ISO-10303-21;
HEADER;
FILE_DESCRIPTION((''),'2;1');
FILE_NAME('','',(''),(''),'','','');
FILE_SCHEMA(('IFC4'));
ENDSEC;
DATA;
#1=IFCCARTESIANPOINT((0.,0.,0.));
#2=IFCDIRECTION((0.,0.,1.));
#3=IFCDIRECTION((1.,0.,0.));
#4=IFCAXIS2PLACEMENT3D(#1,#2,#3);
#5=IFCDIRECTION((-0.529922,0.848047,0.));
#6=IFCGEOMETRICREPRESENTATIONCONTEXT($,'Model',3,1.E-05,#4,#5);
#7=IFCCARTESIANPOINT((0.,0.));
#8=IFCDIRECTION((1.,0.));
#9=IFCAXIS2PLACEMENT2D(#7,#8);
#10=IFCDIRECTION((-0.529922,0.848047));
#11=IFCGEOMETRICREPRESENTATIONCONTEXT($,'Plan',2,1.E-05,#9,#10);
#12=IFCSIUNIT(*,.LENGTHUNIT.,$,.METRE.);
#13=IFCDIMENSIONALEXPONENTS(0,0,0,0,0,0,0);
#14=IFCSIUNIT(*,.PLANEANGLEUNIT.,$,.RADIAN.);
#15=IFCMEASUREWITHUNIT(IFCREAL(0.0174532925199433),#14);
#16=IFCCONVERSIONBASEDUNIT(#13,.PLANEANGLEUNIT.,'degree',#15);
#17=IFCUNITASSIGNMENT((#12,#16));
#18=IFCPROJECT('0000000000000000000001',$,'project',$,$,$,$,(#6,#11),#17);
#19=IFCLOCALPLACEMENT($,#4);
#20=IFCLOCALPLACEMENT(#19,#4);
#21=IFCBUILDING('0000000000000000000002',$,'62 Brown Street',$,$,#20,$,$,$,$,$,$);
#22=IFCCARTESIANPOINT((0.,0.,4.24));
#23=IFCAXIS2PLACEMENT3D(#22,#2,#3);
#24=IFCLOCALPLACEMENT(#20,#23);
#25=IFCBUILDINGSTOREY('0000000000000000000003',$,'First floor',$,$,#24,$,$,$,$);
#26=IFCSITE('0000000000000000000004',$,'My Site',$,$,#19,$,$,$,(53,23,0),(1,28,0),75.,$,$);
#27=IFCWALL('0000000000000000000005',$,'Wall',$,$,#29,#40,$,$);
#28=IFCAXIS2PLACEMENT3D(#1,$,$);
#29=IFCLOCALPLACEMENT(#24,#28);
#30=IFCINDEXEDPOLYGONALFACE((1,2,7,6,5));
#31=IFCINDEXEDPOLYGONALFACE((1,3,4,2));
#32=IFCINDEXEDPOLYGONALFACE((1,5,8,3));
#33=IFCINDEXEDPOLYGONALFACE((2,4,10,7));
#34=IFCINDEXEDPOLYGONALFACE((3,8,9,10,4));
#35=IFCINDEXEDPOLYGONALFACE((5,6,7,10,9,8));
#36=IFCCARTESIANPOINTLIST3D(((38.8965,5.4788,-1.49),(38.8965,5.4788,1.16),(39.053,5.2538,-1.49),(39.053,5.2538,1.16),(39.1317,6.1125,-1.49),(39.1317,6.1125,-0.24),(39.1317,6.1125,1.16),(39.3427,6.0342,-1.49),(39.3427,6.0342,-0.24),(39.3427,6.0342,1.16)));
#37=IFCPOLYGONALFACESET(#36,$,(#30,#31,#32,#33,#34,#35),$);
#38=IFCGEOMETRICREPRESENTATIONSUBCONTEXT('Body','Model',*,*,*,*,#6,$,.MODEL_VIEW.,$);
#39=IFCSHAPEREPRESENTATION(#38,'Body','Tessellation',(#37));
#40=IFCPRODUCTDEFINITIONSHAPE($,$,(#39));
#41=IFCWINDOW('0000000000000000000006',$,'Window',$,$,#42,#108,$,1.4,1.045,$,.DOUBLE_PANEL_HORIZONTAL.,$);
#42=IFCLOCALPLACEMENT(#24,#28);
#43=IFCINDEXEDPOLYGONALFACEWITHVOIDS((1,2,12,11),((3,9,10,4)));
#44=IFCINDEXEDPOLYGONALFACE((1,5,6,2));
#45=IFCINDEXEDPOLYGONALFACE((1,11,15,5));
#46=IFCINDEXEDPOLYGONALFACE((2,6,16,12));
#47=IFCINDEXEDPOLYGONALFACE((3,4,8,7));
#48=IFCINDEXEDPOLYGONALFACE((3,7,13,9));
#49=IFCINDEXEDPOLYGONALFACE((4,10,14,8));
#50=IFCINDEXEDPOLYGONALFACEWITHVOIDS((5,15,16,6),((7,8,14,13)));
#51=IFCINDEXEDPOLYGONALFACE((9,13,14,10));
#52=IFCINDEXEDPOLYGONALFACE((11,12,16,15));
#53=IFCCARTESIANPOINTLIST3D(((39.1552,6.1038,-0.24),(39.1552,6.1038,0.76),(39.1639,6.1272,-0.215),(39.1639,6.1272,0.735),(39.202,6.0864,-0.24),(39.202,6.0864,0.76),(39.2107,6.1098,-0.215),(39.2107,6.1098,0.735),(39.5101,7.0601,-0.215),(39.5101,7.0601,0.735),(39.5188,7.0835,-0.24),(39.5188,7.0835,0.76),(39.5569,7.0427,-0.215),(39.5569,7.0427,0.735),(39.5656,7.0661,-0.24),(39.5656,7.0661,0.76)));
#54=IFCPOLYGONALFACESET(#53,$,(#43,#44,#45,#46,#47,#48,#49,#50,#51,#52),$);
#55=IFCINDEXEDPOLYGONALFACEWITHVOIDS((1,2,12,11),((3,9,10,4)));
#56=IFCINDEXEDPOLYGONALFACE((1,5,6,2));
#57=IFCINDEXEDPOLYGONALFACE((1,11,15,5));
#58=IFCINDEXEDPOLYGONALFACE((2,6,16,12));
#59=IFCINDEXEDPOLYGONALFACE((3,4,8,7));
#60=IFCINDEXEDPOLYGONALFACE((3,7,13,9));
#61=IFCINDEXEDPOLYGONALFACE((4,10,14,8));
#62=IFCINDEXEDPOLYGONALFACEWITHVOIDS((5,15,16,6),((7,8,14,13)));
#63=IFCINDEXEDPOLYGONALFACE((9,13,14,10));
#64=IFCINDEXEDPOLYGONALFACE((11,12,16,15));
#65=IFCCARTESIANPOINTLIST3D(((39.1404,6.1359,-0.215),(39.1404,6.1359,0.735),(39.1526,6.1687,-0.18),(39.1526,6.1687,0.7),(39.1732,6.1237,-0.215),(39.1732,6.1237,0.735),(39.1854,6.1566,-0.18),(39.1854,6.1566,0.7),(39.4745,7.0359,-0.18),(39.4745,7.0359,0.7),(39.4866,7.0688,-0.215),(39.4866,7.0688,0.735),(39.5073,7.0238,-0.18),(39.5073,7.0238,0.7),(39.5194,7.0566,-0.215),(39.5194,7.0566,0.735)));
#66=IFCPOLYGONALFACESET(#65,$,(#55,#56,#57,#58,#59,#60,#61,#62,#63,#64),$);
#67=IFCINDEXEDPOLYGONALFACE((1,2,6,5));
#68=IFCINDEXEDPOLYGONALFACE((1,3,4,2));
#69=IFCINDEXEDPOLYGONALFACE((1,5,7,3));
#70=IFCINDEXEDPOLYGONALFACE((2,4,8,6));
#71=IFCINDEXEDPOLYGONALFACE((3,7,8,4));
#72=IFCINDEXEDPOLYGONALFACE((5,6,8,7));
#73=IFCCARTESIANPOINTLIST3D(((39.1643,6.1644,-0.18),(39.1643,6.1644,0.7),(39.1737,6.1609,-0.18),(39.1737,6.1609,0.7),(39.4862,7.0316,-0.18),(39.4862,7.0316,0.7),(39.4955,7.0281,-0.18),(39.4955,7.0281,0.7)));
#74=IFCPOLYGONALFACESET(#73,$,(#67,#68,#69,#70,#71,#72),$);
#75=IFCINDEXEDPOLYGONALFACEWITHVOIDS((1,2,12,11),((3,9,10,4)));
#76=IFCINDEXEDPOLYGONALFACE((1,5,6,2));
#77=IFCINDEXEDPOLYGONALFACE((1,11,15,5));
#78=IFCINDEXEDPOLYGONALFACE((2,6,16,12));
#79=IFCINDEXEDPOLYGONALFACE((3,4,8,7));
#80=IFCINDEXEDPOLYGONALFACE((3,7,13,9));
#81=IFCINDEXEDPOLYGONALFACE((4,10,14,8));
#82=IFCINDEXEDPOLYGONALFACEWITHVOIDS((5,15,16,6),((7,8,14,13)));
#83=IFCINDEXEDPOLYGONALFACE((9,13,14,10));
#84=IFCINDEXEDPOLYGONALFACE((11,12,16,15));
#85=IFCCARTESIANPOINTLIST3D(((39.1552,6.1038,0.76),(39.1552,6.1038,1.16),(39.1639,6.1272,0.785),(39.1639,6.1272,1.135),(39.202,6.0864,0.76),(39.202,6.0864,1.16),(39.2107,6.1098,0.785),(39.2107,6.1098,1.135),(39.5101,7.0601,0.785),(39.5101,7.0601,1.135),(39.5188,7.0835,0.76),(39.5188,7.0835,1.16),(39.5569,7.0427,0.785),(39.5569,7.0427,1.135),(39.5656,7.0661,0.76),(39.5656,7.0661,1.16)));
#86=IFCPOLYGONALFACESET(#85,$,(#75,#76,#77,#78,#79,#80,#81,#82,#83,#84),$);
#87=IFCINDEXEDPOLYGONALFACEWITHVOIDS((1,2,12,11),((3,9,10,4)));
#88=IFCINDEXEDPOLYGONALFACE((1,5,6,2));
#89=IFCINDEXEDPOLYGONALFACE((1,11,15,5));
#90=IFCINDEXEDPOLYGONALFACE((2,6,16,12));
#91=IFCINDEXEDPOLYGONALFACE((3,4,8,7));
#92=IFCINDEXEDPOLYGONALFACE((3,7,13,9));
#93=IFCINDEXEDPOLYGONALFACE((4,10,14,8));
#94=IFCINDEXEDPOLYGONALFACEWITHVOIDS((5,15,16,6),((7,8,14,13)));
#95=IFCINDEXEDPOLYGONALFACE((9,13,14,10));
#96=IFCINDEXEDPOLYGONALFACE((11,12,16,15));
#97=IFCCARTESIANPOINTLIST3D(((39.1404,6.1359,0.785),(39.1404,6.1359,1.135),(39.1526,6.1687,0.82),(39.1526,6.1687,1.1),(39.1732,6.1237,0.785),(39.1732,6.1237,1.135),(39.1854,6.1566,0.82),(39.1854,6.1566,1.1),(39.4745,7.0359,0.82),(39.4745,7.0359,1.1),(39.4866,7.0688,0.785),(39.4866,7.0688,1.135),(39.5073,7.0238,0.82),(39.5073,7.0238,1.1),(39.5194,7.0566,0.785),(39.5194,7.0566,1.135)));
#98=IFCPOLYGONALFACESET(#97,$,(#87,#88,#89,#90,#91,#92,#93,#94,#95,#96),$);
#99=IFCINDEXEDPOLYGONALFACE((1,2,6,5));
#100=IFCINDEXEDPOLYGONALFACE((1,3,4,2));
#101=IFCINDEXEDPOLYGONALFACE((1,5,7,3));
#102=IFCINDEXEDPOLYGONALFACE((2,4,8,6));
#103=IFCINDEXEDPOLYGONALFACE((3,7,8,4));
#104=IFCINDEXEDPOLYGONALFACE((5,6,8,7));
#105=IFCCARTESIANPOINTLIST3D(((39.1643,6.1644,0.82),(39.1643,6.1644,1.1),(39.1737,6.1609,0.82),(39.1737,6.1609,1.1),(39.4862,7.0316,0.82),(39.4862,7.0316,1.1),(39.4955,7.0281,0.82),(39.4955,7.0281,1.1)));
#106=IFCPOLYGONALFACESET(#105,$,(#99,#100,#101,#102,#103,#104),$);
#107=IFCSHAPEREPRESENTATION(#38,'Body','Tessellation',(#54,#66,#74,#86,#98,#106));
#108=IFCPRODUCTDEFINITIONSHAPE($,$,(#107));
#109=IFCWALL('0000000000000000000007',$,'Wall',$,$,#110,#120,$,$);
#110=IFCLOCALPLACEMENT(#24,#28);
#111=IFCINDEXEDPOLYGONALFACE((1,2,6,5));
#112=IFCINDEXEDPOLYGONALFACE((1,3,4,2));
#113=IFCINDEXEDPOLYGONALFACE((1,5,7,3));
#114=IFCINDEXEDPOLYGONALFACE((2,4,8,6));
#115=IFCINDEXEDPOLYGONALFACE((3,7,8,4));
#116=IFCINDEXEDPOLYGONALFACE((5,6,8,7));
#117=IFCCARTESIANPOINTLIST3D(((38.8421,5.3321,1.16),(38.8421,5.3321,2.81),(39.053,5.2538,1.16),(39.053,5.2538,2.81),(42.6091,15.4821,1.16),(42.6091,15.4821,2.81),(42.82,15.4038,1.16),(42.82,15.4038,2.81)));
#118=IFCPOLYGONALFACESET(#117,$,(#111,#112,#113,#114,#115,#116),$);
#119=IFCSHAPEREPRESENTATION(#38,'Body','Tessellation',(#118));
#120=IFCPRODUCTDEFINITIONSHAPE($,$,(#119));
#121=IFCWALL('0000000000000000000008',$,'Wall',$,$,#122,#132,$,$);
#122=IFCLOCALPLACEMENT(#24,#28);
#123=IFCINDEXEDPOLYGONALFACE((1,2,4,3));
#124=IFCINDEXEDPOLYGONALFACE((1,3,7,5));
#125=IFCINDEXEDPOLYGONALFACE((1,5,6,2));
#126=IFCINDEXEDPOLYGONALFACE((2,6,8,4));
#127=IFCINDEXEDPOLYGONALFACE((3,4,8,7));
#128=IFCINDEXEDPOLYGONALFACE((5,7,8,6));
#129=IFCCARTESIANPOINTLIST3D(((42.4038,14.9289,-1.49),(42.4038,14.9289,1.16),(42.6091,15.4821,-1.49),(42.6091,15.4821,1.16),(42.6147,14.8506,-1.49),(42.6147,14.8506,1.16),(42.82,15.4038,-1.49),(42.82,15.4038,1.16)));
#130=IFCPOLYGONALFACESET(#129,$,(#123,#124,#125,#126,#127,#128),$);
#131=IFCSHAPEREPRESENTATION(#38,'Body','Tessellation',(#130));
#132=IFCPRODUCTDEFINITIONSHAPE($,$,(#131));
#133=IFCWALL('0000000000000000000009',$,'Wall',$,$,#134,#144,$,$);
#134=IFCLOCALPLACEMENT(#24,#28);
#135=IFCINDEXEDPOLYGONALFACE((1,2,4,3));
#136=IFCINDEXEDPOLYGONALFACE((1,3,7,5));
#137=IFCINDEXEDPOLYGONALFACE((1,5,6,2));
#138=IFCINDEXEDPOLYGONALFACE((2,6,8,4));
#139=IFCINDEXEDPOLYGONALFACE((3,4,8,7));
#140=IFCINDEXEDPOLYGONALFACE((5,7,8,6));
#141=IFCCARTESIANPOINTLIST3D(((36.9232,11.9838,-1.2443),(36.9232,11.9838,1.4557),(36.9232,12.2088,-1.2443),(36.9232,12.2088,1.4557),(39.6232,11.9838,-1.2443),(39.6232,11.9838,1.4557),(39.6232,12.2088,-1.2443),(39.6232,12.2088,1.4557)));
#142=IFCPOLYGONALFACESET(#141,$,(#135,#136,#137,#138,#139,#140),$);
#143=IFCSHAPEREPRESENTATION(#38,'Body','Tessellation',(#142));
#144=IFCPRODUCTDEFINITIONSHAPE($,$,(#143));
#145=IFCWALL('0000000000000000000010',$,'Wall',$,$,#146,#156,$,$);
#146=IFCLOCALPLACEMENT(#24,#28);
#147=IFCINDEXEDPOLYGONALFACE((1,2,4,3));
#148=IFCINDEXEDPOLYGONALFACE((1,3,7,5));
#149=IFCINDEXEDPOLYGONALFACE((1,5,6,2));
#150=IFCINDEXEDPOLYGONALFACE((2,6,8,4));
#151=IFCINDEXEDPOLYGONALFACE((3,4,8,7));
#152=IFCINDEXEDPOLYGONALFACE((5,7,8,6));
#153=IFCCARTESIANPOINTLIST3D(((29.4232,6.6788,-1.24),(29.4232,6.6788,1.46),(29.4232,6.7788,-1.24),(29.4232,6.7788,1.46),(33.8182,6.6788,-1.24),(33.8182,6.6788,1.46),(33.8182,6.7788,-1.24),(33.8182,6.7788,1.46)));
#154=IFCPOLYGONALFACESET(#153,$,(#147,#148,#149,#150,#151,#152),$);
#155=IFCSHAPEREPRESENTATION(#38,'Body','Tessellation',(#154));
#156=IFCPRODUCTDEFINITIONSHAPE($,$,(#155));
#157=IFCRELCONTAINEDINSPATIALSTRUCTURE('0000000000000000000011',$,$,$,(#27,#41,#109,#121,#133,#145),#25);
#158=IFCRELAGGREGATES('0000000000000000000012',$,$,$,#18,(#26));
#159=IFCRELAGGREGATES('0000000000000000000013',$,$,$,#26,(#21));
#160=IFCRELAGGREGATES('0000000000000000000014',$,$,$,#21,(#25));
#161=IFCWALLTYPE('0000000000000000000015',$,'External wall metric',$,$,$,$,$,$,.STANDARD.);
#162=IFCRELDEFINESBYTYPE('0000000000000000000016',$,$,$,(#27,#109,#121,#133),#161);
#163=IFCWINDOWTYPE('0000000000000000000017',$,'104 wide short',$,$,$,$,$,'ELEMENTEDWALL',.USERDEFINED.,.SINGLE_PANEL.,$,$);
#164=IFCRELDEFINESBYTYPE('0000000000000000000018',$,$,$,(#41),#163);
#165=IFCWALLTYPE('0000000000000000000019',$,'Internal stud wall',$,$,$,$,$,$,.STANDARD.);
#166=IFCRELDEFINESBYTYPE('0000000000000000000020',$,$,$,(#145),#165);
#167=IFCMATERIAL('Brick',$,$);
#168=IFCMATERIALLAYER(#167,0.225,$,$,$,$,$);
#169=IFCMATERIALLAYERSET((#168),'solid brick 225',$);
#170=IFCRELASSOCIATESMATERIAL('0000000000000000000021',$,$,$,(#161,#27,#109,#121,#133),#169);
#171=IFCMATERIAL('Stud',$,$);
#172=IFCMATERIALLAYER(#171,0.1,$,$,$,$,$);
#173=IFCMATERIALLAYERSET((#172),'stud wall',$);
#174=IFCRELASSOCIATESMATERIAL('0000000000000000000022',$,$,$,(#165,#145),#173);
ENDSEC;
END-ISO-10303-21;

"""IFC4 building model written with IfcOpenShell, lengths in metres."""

from ifc_helpers import new_model, entity, si_unit, converted_unit, direction, frame, origin_with_axes, origin_2d_with_axis, place, context, subcontext, project, spatial, line, indexed_curve, outline, extrude, clip, halfspace, shape, source, transform, mapped, material, layer, layer_set, layer_usage, type_object, type_shapes, element, fill, save


model = new_model("IFC4")

# Units and contexts
model_context = context("Model", 3, precision=1e-05, world=origin_with_axes(), true_north=direction((-0.529922, 0.848047, 0.0)))
plan_context = context("Plan", 2, precision=1e-05, world=origin_2d_with_axis(), true_north=direction((-0.529922, 0.848047)))
body_context_1 = subcontext(model_context, "Body", "Model", "MODEL_VIEW")
body_context_2 = subcontext(plan_context, "Body", "Plan", "PLAN_VIEW")
ifc_project = project(units=[si_unit("LENGTHUNIT", "METRE"), converted_unit("PLANEANGLEUNIT", "degree", entity("IfcReal", 0.0174532925199433), si_unit("PLANEANGLEUNIT", "RADIAN"), dimensions=[0, 0, 0, 0, 0, 0, 0])], contexts=[model_context, plan_context])

# Site, building, storey
site_placement = place(None, origin_with_axes())
site = spatial("IfcSite", under=ifc_project, at=site_placement, Name="My Site", RefLatitude=(53, 23, 0), RefLongitude=(1, 28, 0), RefElevation=75.0)
building_placement = place(site_placement, origin_with_axes())
building = spatial("IfcBuilding", under=site, at=building_placement, Name="62 Brown Street")
storey_placement = place(building_placement, frame((0.0, 0.0, 4.24), z_axis=(0.0, 0.0, 1.0), x_axis=(1.0, 0.0, 0.0)))
storey = spatial("IfcBuildingStorey", under=building, at=storey_placement, Name="First floor")

# Shared definitions
ifc_material_1 = material(Name="Brick")
ifc_layer_1 = layer(ifc_material_1, 0.225)
ifc_layer_set_1 = layer_set([ifc_layer_1], Name="solid brick 225")
wall_type_1 = type_object("IfcWallType", Name="External wall metric", PredefinedType="STANDARD", material=ifc_layer_set_1)

# Wall, opening, window
ifc_layer_usage_1 = layer_usage(ifc_layer_set_1, "AXIS2", "POSITIVE", 0.0)
wall_1_placement = place(storey_placement, frame((39.024, 5.1755, -1.49), z_axis=(0.0, 0.0, 1.0), x_axis=(0.347944, 0.937515, 0.0)))
wall_1 = element("IfcWall", 1, at=wall_1_placement, inside=storey, type_object=wall_type_1, material=ifc_layer_usage_1, Name="Wall", context=body_context_1, shape_type="Clipping", body=[
    clip(extrude(outline(indexed_curve([(0.0, 0.0), (0.0, 0.225), (0.9159, 0.225), (0.9159, 0.0), (0.0, 0.0)], self_intersect=False)), origin_with_axes(), (0.0, 0.0, 1.0), 2.65), halfspace(frame((0.0835, 0.0, -2.75), z_axis=(-0.596248, 0.414701, 0.0), x_axis=(0.156491, 0.224999, 0.0)), False)),
])
shared_shape_1 = source(origin_with_axes(), body_context_1, "Body", "SweptSolid", [
    extrude(outline(indexed_curve([(0.0, 0.0), (1.045, 0.0), (1.045, 1.4), (0.0, 1.4)], segments=[line(1, 2, 3, 4, 1)])), frame((0.0, -0.1, 0.0), z_axis=(0.0, -1.0, 0.0), x_axis=(1.0, 0.0, 0.0)), (0.0, 0.0, -1.0), 0.425),
])
opening_1_placement = place(wall_1_placement, frame((0.9159, 0.0, 1.25), z_axis=(0.0, 0.0, 1.0), x_axis=(1.0, 0.0, 0.0)))
opening_1 = element("IfcOpeningElement", 2, at=opening_1_placement, cuts=wall_1, PredefinedType="OPENING", context=body_context_1, shape_type="MappedRepresentation", body=[
    mapped(shared_shape_1, transform((0.0, 0.0, 0.0), x_axis=(1.0, 0.0, 0.0), y_axis=(0.0, 1.0, 0.0), z_axis=(0.0, 0.0, 1.0), scale=1.0)),
])
window_type_1 = type_object("IfcWindowType", Name="104 wide short", ElementType="ELEMENTEDWALL", PartitioningType="SINGLE_PANEL", PredefinedType="USERDEFINED")
shared_shape_2 = source(origin_with_axes(), body_context_1, "Body", "SweptSolid", [
    extrude(outline(indexed_curve([(0.0, 0.0), (1.045, 0.0), (1.045, 1.0), (0.0, 1.0)], segments=[line(1, 2, 3, 4, 1)]), holes=[indexed_curve([(0.025, 0.025), (1.02, 0.025), (1.02, 0.975), (0.025, 0.975)], segments=[line(1, 2, 3, 4, 1)])]), frame((0.0, 0.15, 0.0), z_axis=(0.0, -1.0, 0.0), x_axis=(1.0, 0.0, 0.0)), (0.0, 0.0, -1.0), 0.05),
    extrude(outline(indexed_curve([(0.0, 0.0), (0.995, 0.0), (0.995, 0.95), (0.0, 0.95)], segments=[line(1, 2, 3, 4, 1)]), holes=[indexed_curve([(0.035, 0.035), (0.96, 0.035), (0.96, 0.915), (0.035, 0.915)], segments=[line(1, 2, 3, 4, 1)])]), frame((0.025, 0.19, 0.025), z_axis=(0.0, -1.0, 0.0), x_axis=(1.0, 0.0, 0.0)), (0.0, 0.0, -1.0), 0.035),
    extrude(outline(indexed_curve([(0.035, 0.035), (0.96, 0.035), (0.96, 0.915), (0.035, 0.915)], segments=[line(1, 2, 3, 4, 1)])), frame((0.025, 0.2025, 0.025), z_axis=(0.0, -1.0, 0.0), x_axis=(1.0, 0.0, 0.0)), (0.0, 0.0, -1.0), 0.01),
    extrude(outline(indexed_curve([(0.0, 0.0), (1.045, 0.0), (1.045, 0.4), (0.0, 0.4)], segments=[line(1, 2, 3, 4, 1)]), holes=[indexed_curve([(0.025, 0.025), (1.02, 0.025), (1.02, 0.375), (0.025, 0.375)], segments=[line(1, 2, 3, 4, 1)])]), frame((0.0, 0.15, 1.0), z_axis=(0.0, -1.0, 0.0), x_axis=(1.0, 0.0, 0.0)), (0.0, 0.0, -1.0), 0.05),
    extrude(outline(indexed_curve([(0.0, 0.0), (0.995, 0.0), (0.995, 0.35), (0.0, 0.35)], segments=[line(1, 2, 3, 4, 1)]), holes=[indexed_curve([(0.035, 0.035), (0.96, 0.035), (0.96, 0.315), (0.035, 0.315)], segments=[line(1, 2, 3, 4, 1)])]), frame((0.025, 0.19, 1.025), z_axis=(0.0, -1.0, 0.0), x_axis=(1.0, 0.0, 0.0)), (0.0, 0.0, -1.0), 0.035),
    extrude(outline(indexed_curve([(0.035, 0.035), (0.96, 0.035), (0.96, 0.315), (0.035, 0.315)], segments=[line(1, 2, 3, 4, 1)])), frame((0.025, 0.2025, 1.025), z_axis=(0.0, -1.0, 0.0), x_axis=(1.0, 0.0, 0.0)), (0.0, 0.0, -1.0), 0.01),
])
shared_shape_3 = source(origin_with_axes(), body_context_2, "Body", "Curve2D", [
    entity("IfcIndexedPolyCurve", entity("IfcCartesianPointList2D", [[0.025, 0.15], [1.02, 0.15]])),
    entity("IfcIndexedPolyCurve", entity("IfcCartesianPointList2D", [[0.0, 0.2], [0.025, 0.2], [0.025, 0.15], [0.0, 0.15]]), [entity("IfcLineIndex", [1, 2, 3, 4, 1])]),
    entity("IfcIndexedPolyCurve", entity("IfcCartesianPointList2D", [[1.045, 0.2], [1.02, 0.2], [1.02, 0.15], [1.045, 0.15]]), [entity("IfcLineIndex", [1, 2, 3, 4, 1])]),
    entity("IfcIndexedPolyCurve", entity("IfcCartesianPointList2D", [[0.025, 0.19], [0.06, 0.19], [0.06, 0.225], [0.025, 0.225]]), [entity("IfcLineIndex", [1, 2, 3, 4, 1])]),
    entity("IfcIndexedPolyCurve", entity("IfcCartesianPointList2D", [[1.02, 0.19], [0.985, 0.19], [0.985, 0.225], [1.02, 0.225]]), [entity("IfcLineIndex", [1, 2, 3, 4, 1])]),
    entity("IfcIndexedPolyCurve", entity("IfcCartesianPointList2D", [[0.06, 0.19], [0.985, 0.19]])),
    entity("IfcIndexedPolyCurve", entity("IfcCartesianPointList2D", [[0.06, 0.225], [0.985, 0.225]])),
    entity("IfcIndexedPolyCurve", entity("IfcCartesianPointList2D", [[0.06, 0.2075], [0.985, 0.2075]])),
])
type_shapes(window_type_1, [shared_shape_2, shared_shape_3])
window_1_placement = place(opening_1_placement, frame((0.0, 0.0, 0.0), z_axis=(0.0, 0.0, 1.0), x_axis=(1.0, 0.0, 0.0)))
window_1 = element("IfcWindow", 3, at=window_1_placement, inside=storey, type_object=window_type_1, Name="Window", OverallHeight=1.4, OverallWidth=1.045, PartitioningType="DOUBLE_PANEL_HORIZONTAL", shapes=[
    shape(body_context_1, "Body", "MappedRepresentation", [mapped(shared_shape_2, transform((0.0, 0.0, 0.0), x_axis=(1.0, 0.0, 0.0), y_axis=(0.0, 1.0, 0.0), z_axis=(0.0, 0.0, 1.0), scale=1.0))]),
    shape(body_context_2, "Body", "MappedRepresentation", [mapped(shared_shape_3, transform((0.0, 0.0, 0.0), x_axis=(1.0, 0.0, 0.0), y_axis=(0.0, 1.0, 0.0), z_axis=(0.0, 0.0, 1.0), scale=1.0))]),
])
fill(opening_1, window_1)

# Walls
ifc_layer_usage_2 = layer_usage(ifc_layer_set_1, "AXIS2", "POSITIVE", 0.0)
wall_2_placement = place(storey_placement, frame((39.053, 5.2538, 1.16), z_axis=(0.0, 0.0, 1.0), x_axis=(0.347944, 0.937515, 0.0)))
element("IfcWall", 4, at=wall_2_placement, inside=storey, type_object=wall_type_1, material=ifc_layer_usage_2, Name="Wall", context=body_context_1, shape_type="SweptSolid", body=[
    extrude(outline(indexed_curve([(0.0, 0.0), (0.0, 0.225), (10.8265, 0.225), (10.8265, 0.0), (0.0, 0.0)], self_intersect=False)), origin_with_axes(), (0.0, 0.0, 1.0), 1.65),
])
ifc_layer_usage_3 = layer_usage(ifc_layer_set_1, "AXIS2", "POSITIVE", 0.0)
wall_3_placement = place(storey_placement, frame((42.6147, 14.8506, -1.49), z_axis=(0.0, 0.0, 1.0), x_axis=(0.347944, 0.937515, 0.0)))
element("IfcWall", 5, at=wall_3_placement, inside=storey, type_object=wall_type_1, material=ifc_layer_usage_3, Name="Wall", context=body_context_1, shape_type="SweptSolid", body=[
    extrude(outline(indexed_curve([(0.0, 0.0), (0.0, 0.225), (0.5901, 0.225), (0.5901, 0.0), (0.0, 0.0)], self_intersect=False)), origin_with_axes(), (0.0, 0.0, 1.0), 2.65),
])
ifc_layer_usage_4 = layer_usage(ifc_layer_set_1, "AXIS2", "POSITIVE", 0.0)
wall_4_placement = place(storey_placement, frame((36.9232, 11.9838, -1.2443), z_axis=(0.0, 0.0, 1.0), x_axis=(1.0, 0.0, 0.0)))
element("IfcWall", 6, at=wall_4_placement, inside=storey, type_object=wall_type_1, material=ifc_layer_usage_4, Name="Wall", context=body_context_1, shape_type="SweptSolid", body=[
    extrude(outline(indexed_curve([(0.0, 0.0), (0.0, 0.225), (2.7, 0.225), (2.7, 0.0), (0.0, 0.0)], self_intersect=False)), origin_with_axes(), (0.0, 0.0, 1.0), 2.7),
])

# Shared definitions
ifc_material_2 = material(Name="Stud")
ifc_layer_2 = layer(ifc_material_2, 0.1)
ifc_layer_set_2 = layer_set([ifc_layer_2], Name="stud wall")
wall_type_2 = type_object("IfcWallType", Name="Internal stud wall", PredefinedType="STANDARD", material=ifc_layer_set_2)

# Wall
ifc_layer_usage_5 = layer_usage(ifc_layer_set_2, "AXIS2", "POSITIVE", 0.0)
wall_5_placement = place(storey_placement, frame((33.8182, 6.7788, -1.24), z_axis=(0.0, 0.0, 1.0), x_axis=(-1.0, 0.000001, 0.0)))
element("IfcWall", 7, at=wall_5_placement, inside=storey, type_object=wall_type_2, material=ifc_layer_usage_5, Name="Wall", context=body_context_1, shape_type="SweptSolid", body=[
    extrude(outline(indexed_curve([(0.0, 0.0), (0.0, 0.1), (4.395, 0.1), (4.395, 0.0), (0.0, 0.0)], self_intersect=False)), origin_with_axes(), (0.0, 0.0, 1.0), 2.7),
])

save(model, "model.ifc")
